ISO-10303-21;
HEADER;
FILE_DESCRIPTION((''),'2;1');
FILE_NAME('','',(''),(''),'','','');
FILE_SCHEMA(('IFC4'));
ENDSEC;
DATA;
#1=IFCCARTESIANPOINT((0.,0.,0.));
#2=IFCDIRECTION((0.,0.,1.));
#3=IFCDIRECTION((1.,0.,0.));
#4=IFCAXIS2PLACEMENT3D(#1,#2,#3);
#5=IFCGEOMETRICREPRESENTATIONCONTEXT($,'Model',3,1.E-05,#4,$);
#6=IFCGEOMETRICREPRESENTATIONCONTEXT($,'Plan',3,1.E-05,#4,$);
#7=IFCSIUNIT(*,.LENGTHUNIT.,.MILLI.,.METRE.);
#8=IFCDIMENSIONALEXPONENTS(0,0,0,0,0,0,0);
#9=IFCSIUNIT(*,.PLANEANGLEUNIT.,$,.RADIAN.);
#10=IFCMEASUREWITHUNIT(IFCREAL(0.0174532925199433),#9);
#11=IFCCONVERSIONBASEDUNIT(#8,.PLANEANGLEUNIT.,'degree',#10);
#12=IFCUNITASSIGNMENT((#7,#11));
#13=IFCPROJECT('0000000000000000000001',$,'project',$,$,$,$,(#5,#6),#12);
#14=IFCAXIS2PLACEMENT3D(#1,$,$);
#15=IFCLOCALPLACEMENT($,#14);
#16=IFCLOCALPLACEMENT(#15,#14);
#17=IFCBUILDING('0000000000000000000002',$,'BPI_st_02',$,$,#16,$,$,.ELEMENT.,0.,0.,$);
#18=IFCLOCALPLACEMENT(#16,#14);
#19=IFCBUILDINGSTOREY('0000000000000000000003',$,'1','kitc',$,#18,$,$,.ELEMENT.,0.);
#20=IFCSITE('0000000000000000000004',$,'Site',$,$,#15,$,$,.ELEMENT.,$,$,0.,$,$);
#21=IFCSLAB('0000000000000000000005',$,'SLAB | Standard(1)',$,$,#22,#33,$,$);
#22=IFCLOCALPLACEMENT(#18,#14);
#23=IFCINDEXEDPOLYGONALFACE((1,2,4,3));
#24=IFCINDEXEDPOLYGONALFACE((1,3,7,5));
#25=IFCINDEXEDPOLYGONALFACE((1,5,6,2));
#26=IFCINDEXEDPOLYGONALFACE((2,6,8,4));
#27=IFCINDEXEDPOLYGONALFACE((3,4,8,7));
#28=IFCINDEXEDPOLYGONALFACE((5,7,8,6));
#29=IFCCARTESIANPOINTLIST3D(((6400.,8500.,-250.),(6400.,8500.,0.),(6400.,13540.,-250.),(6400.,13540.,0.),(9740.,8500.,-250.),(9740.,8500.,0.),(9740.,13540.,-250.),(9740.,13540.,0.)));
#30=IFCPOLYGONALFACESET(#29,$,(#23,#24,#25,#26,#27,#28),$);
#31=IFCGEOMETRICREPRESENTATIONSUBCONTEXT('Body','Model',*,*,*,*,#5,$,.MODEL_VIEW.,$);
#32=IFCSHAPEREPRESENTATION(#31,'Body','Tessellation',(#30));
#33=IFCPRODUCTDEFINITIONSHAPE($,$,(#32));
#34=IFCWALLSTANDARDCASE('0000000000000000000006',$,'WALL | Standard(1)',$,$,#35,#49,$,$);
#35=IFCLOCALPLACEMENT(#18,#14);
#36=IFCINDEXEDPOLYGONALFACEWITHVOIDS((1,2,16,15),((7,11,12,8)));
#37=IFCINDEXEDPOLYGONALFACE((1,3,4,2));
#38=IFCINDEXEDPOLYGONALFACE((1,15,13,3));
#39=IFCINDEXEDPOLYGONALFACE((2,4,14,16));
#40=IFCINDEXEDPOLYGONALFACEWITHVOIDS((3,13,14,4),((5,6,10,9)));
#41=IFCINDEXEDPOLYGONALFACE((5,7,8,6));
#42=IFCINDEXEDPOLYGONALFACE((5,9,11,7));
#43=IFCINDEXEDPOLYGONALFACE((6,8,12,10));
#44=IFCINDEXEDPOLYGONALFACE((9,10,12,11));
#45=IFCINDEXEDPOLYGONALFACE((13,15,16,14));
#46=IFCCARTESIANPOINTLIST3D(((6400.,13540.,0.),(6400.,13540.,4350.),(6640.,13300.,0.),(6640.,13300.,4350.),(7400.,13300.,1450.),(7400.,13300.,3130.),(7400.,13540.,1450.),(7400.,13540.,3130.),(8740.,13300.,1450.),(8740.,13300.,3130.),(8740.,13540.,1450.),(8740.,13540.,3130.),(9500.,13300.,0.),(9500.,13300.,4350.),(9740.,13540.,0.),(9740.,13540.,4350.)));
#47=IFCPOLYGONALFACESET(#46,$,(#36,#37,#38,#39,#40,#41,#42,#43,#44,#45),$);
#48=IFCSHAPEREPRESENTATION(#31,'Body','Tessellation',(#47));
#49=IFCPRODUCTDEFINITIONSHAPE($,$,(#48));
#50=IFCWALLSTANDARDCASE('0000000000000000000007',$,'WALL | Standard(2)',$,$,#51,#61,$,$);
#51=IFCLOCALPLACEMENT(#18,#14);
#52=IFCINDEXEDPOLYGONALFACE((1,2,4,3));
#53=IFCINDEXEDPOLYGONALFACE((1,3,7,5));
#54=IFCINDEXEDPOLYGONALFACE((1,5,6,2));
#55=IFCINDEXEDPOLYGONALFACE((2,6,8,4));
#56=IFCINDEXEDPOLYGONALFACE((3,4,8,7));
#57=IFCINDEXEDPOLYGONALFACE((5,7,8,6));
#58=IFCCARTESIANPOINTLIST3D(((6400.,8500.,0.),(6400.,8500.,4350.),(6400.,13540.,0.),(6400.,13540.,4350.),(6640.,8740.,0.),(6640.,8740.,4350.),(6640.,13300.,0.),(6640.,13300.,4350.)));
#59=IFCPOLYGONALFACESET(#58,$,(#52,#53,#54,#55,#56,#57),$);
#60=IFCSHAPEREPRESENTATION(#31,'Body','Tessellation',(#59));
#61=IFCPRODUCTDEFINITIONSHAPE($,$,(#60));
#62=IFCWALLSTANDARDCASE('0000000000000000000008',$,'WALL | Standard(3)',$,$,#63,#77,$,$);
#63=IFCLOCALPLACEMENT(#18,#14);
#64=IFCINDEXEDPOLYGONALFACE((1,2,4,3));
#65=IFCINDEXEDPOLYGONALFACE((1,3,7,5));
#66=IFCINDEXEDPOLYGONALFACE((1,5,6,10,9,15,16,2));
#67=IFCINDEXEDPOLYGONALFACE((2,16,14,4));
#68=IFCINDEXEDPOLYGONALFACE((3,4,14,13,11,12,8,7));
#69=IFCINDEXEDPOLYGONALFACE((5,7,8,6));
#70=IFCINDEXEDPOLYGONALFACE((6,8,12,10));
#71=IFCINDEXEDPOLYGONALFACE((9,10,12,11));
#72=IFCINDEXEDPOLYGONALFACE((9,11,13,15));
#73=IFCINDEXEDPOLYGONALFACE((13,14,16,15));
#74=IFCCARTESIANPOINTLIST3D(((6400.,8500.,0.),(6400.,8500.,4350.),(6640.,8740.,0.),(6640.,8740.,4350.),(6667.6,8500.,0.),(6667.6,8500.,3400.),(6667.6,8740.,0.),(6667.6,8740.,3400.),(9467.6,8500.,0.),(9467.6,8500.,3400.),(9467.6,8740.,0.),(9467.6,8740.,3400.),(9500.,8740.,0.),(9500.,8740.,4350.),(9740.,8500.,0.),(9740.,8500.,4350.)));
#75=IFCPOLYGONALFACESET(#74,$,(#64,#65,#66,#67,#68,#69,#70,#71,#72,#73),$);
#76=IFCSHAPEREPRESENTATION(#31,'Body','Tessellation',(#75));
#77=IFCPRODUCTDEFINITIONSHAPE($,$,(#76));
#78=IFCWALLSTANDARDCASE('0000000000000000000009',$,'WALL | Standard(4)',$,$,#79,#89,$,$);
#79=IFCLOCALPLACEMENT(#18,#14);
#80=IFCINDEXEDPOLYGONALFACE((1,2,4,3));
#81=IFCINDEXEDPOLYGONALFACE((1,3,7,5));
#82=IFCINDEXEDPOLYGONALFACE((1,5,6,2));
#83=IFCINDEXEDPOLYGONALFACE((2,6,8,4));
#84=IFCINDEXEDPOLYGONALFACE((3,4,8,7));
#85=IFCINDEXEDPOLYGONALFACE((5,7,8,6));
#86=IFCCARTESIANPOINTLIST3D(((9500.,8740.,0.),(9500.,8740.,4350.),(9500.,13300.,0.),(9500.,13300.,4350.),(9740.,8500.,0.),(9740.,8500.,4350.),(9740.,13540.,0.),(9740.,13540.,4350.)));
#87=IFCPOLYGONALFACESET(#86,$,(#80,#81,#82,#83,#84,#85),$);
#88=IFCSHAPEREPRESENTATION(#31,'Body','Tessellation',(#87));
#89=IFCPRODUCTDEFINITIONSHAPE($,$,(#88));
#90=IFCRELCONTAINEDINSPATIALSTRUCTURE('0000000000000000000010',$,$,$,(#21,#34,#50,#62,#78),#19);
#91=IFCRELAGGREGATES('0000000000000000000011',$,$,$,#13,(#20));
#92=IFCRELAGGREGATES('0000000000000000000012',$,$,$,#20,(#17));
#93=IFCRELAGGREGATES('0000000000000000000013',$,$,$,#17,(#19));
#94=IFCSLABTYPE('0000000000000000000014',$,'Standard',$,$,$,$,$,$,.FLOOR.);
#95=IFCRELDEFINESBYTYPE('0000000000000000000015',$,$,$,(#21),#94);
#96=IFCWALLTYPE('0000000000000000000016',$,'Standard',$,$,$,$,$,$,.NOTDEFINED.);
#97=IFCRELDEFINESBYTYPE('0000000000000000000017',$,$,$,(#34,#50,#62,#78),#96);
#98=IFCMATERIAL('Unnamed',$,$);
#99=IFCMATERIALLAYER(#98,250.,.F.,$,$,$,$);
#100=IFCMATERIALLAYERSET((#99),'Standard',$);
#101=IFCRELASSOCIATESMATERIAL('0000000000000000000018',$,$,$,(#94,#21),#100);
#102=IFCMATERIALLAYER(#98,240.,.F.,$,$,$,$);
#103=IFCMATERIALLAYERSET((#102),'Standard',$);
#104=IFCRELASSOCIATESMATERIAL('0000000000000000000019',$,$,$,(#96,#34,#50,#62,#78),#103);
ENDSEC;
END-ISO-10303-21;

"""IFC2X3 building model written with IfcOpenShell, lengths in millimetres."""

from ifc_helpers import new_model, entity, si_unit, converted_unit, frame, frame_2d, origin, origin_with_axes, origin_2d_with_axis, place, context, subcontext, project, spatial, polyline, segment, composite_curve, rectangle, outline, extrude, material, layer, layer_set, layer_usage, type_object, element, save


model = new_model("IFC2X3")

# Units and contexts
model_context = context("Model", 3, precision=1e-05, world=origin_with_axes())
plan_context = context("Plan", 3, precision=1e-05, world=origin_with_axes())
body_context = subcontext(model_context, "Body", "Model", "MODEL_VIEW")
ifc_project = project(units=[si_unit("LENGTHUNIT", "METRE", prefix="MILLI"), converted_unit("PLANEANGLEUNIT", "degree", entity("IfcReal", 0.0174532925199433), si_unit("PLANEANGLEUNIT", "RADIAN"), dimensions=[0, 0, 0, 0, 0, 0, 0])], contexts=[model_context, plan_context])

# Site, building, storey
site_placement = place(None, origin())
site = spatial("IfcSite", under=ifc_project, at=site_placement, Name="Site", CompositionType="ELEMENT", RefElevation=0.0)
building_placement = place(site_placement, origin())
building = spatial("IfcBuilding", under=site, at=building_placement, Name="BPI_st_02", CompositionType="ELEMENT", ElevationOfRefHeight=0.0, ElevationOfTerrain=0.0)
storey_placement = place(building_placement, origin())
storey = spatial("IfcBuildingStorey", under=building, at=storey_placement, Name="1", Description="kitc", CompositionType="ELEMENT", Elevation=0.0)

# Slab
ifc_material = material(Name="Unnamed")
ifc_layer_1 = layer(ifc_material, 250.0, ventilated=False)
ifc_layer_set_1 = layer_set([ifc_layer_1], Name="Standard")
ifc_layer_usage_1 = layer_usage(ifc_layer_set_1, "AXIS3", "POSITIVE", 0.0)
slab_type = type_object("IfcSlabType", Name="Standard", PredefinedType="FLOOR", material=ifc_layer_set_1)
slab_placement = place(storey_placement, frame((22540.0, 13540.0, 0.0), z_axis=(0.0, 0.0, 1.0), x_axis=(-1.0, 0.0, 0.0)))
element("IfcSlab", 1, at=slab_placement, inside=storey, type_object=slab_type, material=ifc_layer_usage_1, Name="SLAB | Standard(1)", context=body_context, shape_type="SweptSolid", body=[
    extrude(rectangle(XDim=3340.0, YDim=5040.0, at=frame_2d((14470.0, 2520.0), x_axis=(1.0, 0.0))), frame((0.0, 0.0, -250.0)), (0.0, 0.0, 1.0), 250.0),
])

# Wall, opening
ifc_layer_2 = layer(ifc_material, 240.0, ventilated=False)
ifc_layer_set_2 = layer_set([ifc_layer_2], Name="Standard")
ifc_layer_usage_2 = layer_usage(ifc_layer_set_2, "AXIS2", "POSITIVE", -120.0)
wall_type = type_object("IfcWallType", Name="Standard", PredefinedType="NOTDEFINED", material=ifc_layer_set_2)
wall_1_placement = place(storey_placement, frame((6520.0, 13420.0, 0.0)))
wall_1 = element("IfcWallStandardCase", 2, at=wall_1_placement, inside=storey, type_object=wall_type, material=ifc_layer_usage_2, Name="WALL | Standard(1)", context=body_context, shape_type="SweptSolid", body=[
    extrude(outline(composite_curve([segment(polyline([(-120.0, 120.0), (120.0, -120.0)]), True, "CONTINUOUS"), segment(polyline([(120.0, -120.0), (2980.0, -120.0)]), True, "CONTINUOUS"), segment(polyline([(2980.0, -120.0), (3220.0, 120.0)]), True, "CONTINUOUS"), segment(polyline([(3220.0, 120.0), (-120.0, 120.0)]), True, "CONTINUOUS")], self_intersect=False)), origin(), (0.0, 0.0, 1.0), 4350.0),
])
opening_1_placement = place(wall_1_placement, frame((880.0, 0.0, 1450.0)))
element("IfcOpeningElement", 3, at=opening_1_placement, cuts=wall_1, context=body_context, shape_type="SweptSolid", body=[
    extrude(rectangle(XDim=1340.0, YDim=1680.0, at=origin_2d_with_axis()), frame((670.0, 120.0, 840.0), z_axis=(0.0, -1.0, 0.0), x_axis=(1.0, 0.0, 0.0)), (0.0, 0.0, 1.0), 240.0),
])

# Wall
ifc_layer_usage_3 = layer_usage(ifc_layer_set_2, "AXIS2", "POSITIVE", -120.0)
wall_2_placement = place(storey_placement, frame((6520.0, 8620.0, 0.0), z_axis=(0.0, 0.0, 1.0), x_axis=(0.0, 1.0, 0.0)))
element("IfcWallStandardCase", 4, at=wall_2_placement, inside=storey, type_object=wall_type, material=ifc_layer_usage_3, Name="WALL | Standard(2)", context=body_context, shape_type="SweptSolid", body=[
    extrude(outline(composite_curve([segment(polyline([(-120.0, 120.0), (120.0, -120.0)]), True, "CONTINUOUS"), segment(polyline([(120.0, -120.0), (4680.0, -120.0)]), True, "CONTINUOUS"), segment(polyline([(4680.0, -120.0), (4920.0, 120.0)]), True, "CONTINUOUS"), segment(polyline([(4920.0, 120.0), (-120.0, 120.0)]), True, "CONTINUOUS")], self_intersect=False)), origin(), (0.0, 0.0, 1.0), 4350.0),
])

# Wall, opening
ifc_layer_usage_4 = layer_usage(ifc_layer_set_2, "AXIS2", "POSITIVE", -120.0)
wall_3_placement = place(storey_placement, frame((6520.0, 8620.0, 0.0)))
wall_3 = element("IfcWallStandardCase", 5, at=wall_3_placement, inside=storey, type_object=wall_type, material=ifc_layer_usage_4, Name="WALL | Standard(3)", context=body_context, shape_type="SweptSolid", body=[
    extrude(outline(composite_curve([segment(polyline([(120.0, 120.0), (-120.0, -120.0)]), True, "CONTINUOUS"), segment(polyline([(-120.0, -120.0), (3220.0, -120.0)]), True, "CONTINUOUS"), segment(polyline([(3220.0, -120.0), (2980.0, 120.0)]), True, "CONTINUOUS"), segment(polyline([(2980.0, 120.0), (120.0, 120.0)]), True, "CONTINUOUS")], self_intersect=False)), origin(), (0.0, 0.0, 1.0), 4350.0),
])
opening_2_placement = place(wall_3_placement, frame((147.5, 0.0, 0.0)))
element("IfcOpeningElement", 6, at=opening_2_placement, cuts=wall_3, context=body_context, shape_type="SweptSolid", body=[
    extrude(rectangle(XDim=2800.0, YDim=3400.0, at=origin_2d_with_axis()), frame((1400.0, 120.0, 1700.0), z_axis=(0.0, -1.0, 0.0), x_axis=(1.0, 0.0, 0.0)), (0.0, 0.0, 1.0), 240.0),
])

# Wall
ifc_layer_usage_5 = layer_usage(ifc_layer_set_2, "AXIS2", "POSITIVE", -120.0)
wall_4_placement = place(storey_placement, frame((9620.0, 8620.0, 0.0), z_axis=(0.0, 0.0, 1.0), x_axis=(0.0, 1.0, 0.0)))
element("IfcWallStandardCase", 7, at=wall_4_placement, inside=storey, type_object=wall_type, material=ifc_layer_usage_5, Name="WALL | Standard(4)", context=body_context, shape_type="SweptSolid", body=[
    extrude(outline(composite_curve([segment(polyline([(120.0, 120.0), (-120.0, -120.0)]), True, "CONTINUOUS"), segment(polyline([(-120.0, -120.0), (4920.0, -120.0)]), True, "CONTINUOUS"), segment(polyline([(4920.0, -120.0), (4680.0, 120.0)]), True, "CONTINUOUS"), segment(polyline([(4680.0, 120.0), (120.0, 120.0)]), True, "CONTINUOUS")], self_intersect=False)), origin(), (0.0, 0.0, 1.0), 4350.0),
])

save(model, "model.ifc")
